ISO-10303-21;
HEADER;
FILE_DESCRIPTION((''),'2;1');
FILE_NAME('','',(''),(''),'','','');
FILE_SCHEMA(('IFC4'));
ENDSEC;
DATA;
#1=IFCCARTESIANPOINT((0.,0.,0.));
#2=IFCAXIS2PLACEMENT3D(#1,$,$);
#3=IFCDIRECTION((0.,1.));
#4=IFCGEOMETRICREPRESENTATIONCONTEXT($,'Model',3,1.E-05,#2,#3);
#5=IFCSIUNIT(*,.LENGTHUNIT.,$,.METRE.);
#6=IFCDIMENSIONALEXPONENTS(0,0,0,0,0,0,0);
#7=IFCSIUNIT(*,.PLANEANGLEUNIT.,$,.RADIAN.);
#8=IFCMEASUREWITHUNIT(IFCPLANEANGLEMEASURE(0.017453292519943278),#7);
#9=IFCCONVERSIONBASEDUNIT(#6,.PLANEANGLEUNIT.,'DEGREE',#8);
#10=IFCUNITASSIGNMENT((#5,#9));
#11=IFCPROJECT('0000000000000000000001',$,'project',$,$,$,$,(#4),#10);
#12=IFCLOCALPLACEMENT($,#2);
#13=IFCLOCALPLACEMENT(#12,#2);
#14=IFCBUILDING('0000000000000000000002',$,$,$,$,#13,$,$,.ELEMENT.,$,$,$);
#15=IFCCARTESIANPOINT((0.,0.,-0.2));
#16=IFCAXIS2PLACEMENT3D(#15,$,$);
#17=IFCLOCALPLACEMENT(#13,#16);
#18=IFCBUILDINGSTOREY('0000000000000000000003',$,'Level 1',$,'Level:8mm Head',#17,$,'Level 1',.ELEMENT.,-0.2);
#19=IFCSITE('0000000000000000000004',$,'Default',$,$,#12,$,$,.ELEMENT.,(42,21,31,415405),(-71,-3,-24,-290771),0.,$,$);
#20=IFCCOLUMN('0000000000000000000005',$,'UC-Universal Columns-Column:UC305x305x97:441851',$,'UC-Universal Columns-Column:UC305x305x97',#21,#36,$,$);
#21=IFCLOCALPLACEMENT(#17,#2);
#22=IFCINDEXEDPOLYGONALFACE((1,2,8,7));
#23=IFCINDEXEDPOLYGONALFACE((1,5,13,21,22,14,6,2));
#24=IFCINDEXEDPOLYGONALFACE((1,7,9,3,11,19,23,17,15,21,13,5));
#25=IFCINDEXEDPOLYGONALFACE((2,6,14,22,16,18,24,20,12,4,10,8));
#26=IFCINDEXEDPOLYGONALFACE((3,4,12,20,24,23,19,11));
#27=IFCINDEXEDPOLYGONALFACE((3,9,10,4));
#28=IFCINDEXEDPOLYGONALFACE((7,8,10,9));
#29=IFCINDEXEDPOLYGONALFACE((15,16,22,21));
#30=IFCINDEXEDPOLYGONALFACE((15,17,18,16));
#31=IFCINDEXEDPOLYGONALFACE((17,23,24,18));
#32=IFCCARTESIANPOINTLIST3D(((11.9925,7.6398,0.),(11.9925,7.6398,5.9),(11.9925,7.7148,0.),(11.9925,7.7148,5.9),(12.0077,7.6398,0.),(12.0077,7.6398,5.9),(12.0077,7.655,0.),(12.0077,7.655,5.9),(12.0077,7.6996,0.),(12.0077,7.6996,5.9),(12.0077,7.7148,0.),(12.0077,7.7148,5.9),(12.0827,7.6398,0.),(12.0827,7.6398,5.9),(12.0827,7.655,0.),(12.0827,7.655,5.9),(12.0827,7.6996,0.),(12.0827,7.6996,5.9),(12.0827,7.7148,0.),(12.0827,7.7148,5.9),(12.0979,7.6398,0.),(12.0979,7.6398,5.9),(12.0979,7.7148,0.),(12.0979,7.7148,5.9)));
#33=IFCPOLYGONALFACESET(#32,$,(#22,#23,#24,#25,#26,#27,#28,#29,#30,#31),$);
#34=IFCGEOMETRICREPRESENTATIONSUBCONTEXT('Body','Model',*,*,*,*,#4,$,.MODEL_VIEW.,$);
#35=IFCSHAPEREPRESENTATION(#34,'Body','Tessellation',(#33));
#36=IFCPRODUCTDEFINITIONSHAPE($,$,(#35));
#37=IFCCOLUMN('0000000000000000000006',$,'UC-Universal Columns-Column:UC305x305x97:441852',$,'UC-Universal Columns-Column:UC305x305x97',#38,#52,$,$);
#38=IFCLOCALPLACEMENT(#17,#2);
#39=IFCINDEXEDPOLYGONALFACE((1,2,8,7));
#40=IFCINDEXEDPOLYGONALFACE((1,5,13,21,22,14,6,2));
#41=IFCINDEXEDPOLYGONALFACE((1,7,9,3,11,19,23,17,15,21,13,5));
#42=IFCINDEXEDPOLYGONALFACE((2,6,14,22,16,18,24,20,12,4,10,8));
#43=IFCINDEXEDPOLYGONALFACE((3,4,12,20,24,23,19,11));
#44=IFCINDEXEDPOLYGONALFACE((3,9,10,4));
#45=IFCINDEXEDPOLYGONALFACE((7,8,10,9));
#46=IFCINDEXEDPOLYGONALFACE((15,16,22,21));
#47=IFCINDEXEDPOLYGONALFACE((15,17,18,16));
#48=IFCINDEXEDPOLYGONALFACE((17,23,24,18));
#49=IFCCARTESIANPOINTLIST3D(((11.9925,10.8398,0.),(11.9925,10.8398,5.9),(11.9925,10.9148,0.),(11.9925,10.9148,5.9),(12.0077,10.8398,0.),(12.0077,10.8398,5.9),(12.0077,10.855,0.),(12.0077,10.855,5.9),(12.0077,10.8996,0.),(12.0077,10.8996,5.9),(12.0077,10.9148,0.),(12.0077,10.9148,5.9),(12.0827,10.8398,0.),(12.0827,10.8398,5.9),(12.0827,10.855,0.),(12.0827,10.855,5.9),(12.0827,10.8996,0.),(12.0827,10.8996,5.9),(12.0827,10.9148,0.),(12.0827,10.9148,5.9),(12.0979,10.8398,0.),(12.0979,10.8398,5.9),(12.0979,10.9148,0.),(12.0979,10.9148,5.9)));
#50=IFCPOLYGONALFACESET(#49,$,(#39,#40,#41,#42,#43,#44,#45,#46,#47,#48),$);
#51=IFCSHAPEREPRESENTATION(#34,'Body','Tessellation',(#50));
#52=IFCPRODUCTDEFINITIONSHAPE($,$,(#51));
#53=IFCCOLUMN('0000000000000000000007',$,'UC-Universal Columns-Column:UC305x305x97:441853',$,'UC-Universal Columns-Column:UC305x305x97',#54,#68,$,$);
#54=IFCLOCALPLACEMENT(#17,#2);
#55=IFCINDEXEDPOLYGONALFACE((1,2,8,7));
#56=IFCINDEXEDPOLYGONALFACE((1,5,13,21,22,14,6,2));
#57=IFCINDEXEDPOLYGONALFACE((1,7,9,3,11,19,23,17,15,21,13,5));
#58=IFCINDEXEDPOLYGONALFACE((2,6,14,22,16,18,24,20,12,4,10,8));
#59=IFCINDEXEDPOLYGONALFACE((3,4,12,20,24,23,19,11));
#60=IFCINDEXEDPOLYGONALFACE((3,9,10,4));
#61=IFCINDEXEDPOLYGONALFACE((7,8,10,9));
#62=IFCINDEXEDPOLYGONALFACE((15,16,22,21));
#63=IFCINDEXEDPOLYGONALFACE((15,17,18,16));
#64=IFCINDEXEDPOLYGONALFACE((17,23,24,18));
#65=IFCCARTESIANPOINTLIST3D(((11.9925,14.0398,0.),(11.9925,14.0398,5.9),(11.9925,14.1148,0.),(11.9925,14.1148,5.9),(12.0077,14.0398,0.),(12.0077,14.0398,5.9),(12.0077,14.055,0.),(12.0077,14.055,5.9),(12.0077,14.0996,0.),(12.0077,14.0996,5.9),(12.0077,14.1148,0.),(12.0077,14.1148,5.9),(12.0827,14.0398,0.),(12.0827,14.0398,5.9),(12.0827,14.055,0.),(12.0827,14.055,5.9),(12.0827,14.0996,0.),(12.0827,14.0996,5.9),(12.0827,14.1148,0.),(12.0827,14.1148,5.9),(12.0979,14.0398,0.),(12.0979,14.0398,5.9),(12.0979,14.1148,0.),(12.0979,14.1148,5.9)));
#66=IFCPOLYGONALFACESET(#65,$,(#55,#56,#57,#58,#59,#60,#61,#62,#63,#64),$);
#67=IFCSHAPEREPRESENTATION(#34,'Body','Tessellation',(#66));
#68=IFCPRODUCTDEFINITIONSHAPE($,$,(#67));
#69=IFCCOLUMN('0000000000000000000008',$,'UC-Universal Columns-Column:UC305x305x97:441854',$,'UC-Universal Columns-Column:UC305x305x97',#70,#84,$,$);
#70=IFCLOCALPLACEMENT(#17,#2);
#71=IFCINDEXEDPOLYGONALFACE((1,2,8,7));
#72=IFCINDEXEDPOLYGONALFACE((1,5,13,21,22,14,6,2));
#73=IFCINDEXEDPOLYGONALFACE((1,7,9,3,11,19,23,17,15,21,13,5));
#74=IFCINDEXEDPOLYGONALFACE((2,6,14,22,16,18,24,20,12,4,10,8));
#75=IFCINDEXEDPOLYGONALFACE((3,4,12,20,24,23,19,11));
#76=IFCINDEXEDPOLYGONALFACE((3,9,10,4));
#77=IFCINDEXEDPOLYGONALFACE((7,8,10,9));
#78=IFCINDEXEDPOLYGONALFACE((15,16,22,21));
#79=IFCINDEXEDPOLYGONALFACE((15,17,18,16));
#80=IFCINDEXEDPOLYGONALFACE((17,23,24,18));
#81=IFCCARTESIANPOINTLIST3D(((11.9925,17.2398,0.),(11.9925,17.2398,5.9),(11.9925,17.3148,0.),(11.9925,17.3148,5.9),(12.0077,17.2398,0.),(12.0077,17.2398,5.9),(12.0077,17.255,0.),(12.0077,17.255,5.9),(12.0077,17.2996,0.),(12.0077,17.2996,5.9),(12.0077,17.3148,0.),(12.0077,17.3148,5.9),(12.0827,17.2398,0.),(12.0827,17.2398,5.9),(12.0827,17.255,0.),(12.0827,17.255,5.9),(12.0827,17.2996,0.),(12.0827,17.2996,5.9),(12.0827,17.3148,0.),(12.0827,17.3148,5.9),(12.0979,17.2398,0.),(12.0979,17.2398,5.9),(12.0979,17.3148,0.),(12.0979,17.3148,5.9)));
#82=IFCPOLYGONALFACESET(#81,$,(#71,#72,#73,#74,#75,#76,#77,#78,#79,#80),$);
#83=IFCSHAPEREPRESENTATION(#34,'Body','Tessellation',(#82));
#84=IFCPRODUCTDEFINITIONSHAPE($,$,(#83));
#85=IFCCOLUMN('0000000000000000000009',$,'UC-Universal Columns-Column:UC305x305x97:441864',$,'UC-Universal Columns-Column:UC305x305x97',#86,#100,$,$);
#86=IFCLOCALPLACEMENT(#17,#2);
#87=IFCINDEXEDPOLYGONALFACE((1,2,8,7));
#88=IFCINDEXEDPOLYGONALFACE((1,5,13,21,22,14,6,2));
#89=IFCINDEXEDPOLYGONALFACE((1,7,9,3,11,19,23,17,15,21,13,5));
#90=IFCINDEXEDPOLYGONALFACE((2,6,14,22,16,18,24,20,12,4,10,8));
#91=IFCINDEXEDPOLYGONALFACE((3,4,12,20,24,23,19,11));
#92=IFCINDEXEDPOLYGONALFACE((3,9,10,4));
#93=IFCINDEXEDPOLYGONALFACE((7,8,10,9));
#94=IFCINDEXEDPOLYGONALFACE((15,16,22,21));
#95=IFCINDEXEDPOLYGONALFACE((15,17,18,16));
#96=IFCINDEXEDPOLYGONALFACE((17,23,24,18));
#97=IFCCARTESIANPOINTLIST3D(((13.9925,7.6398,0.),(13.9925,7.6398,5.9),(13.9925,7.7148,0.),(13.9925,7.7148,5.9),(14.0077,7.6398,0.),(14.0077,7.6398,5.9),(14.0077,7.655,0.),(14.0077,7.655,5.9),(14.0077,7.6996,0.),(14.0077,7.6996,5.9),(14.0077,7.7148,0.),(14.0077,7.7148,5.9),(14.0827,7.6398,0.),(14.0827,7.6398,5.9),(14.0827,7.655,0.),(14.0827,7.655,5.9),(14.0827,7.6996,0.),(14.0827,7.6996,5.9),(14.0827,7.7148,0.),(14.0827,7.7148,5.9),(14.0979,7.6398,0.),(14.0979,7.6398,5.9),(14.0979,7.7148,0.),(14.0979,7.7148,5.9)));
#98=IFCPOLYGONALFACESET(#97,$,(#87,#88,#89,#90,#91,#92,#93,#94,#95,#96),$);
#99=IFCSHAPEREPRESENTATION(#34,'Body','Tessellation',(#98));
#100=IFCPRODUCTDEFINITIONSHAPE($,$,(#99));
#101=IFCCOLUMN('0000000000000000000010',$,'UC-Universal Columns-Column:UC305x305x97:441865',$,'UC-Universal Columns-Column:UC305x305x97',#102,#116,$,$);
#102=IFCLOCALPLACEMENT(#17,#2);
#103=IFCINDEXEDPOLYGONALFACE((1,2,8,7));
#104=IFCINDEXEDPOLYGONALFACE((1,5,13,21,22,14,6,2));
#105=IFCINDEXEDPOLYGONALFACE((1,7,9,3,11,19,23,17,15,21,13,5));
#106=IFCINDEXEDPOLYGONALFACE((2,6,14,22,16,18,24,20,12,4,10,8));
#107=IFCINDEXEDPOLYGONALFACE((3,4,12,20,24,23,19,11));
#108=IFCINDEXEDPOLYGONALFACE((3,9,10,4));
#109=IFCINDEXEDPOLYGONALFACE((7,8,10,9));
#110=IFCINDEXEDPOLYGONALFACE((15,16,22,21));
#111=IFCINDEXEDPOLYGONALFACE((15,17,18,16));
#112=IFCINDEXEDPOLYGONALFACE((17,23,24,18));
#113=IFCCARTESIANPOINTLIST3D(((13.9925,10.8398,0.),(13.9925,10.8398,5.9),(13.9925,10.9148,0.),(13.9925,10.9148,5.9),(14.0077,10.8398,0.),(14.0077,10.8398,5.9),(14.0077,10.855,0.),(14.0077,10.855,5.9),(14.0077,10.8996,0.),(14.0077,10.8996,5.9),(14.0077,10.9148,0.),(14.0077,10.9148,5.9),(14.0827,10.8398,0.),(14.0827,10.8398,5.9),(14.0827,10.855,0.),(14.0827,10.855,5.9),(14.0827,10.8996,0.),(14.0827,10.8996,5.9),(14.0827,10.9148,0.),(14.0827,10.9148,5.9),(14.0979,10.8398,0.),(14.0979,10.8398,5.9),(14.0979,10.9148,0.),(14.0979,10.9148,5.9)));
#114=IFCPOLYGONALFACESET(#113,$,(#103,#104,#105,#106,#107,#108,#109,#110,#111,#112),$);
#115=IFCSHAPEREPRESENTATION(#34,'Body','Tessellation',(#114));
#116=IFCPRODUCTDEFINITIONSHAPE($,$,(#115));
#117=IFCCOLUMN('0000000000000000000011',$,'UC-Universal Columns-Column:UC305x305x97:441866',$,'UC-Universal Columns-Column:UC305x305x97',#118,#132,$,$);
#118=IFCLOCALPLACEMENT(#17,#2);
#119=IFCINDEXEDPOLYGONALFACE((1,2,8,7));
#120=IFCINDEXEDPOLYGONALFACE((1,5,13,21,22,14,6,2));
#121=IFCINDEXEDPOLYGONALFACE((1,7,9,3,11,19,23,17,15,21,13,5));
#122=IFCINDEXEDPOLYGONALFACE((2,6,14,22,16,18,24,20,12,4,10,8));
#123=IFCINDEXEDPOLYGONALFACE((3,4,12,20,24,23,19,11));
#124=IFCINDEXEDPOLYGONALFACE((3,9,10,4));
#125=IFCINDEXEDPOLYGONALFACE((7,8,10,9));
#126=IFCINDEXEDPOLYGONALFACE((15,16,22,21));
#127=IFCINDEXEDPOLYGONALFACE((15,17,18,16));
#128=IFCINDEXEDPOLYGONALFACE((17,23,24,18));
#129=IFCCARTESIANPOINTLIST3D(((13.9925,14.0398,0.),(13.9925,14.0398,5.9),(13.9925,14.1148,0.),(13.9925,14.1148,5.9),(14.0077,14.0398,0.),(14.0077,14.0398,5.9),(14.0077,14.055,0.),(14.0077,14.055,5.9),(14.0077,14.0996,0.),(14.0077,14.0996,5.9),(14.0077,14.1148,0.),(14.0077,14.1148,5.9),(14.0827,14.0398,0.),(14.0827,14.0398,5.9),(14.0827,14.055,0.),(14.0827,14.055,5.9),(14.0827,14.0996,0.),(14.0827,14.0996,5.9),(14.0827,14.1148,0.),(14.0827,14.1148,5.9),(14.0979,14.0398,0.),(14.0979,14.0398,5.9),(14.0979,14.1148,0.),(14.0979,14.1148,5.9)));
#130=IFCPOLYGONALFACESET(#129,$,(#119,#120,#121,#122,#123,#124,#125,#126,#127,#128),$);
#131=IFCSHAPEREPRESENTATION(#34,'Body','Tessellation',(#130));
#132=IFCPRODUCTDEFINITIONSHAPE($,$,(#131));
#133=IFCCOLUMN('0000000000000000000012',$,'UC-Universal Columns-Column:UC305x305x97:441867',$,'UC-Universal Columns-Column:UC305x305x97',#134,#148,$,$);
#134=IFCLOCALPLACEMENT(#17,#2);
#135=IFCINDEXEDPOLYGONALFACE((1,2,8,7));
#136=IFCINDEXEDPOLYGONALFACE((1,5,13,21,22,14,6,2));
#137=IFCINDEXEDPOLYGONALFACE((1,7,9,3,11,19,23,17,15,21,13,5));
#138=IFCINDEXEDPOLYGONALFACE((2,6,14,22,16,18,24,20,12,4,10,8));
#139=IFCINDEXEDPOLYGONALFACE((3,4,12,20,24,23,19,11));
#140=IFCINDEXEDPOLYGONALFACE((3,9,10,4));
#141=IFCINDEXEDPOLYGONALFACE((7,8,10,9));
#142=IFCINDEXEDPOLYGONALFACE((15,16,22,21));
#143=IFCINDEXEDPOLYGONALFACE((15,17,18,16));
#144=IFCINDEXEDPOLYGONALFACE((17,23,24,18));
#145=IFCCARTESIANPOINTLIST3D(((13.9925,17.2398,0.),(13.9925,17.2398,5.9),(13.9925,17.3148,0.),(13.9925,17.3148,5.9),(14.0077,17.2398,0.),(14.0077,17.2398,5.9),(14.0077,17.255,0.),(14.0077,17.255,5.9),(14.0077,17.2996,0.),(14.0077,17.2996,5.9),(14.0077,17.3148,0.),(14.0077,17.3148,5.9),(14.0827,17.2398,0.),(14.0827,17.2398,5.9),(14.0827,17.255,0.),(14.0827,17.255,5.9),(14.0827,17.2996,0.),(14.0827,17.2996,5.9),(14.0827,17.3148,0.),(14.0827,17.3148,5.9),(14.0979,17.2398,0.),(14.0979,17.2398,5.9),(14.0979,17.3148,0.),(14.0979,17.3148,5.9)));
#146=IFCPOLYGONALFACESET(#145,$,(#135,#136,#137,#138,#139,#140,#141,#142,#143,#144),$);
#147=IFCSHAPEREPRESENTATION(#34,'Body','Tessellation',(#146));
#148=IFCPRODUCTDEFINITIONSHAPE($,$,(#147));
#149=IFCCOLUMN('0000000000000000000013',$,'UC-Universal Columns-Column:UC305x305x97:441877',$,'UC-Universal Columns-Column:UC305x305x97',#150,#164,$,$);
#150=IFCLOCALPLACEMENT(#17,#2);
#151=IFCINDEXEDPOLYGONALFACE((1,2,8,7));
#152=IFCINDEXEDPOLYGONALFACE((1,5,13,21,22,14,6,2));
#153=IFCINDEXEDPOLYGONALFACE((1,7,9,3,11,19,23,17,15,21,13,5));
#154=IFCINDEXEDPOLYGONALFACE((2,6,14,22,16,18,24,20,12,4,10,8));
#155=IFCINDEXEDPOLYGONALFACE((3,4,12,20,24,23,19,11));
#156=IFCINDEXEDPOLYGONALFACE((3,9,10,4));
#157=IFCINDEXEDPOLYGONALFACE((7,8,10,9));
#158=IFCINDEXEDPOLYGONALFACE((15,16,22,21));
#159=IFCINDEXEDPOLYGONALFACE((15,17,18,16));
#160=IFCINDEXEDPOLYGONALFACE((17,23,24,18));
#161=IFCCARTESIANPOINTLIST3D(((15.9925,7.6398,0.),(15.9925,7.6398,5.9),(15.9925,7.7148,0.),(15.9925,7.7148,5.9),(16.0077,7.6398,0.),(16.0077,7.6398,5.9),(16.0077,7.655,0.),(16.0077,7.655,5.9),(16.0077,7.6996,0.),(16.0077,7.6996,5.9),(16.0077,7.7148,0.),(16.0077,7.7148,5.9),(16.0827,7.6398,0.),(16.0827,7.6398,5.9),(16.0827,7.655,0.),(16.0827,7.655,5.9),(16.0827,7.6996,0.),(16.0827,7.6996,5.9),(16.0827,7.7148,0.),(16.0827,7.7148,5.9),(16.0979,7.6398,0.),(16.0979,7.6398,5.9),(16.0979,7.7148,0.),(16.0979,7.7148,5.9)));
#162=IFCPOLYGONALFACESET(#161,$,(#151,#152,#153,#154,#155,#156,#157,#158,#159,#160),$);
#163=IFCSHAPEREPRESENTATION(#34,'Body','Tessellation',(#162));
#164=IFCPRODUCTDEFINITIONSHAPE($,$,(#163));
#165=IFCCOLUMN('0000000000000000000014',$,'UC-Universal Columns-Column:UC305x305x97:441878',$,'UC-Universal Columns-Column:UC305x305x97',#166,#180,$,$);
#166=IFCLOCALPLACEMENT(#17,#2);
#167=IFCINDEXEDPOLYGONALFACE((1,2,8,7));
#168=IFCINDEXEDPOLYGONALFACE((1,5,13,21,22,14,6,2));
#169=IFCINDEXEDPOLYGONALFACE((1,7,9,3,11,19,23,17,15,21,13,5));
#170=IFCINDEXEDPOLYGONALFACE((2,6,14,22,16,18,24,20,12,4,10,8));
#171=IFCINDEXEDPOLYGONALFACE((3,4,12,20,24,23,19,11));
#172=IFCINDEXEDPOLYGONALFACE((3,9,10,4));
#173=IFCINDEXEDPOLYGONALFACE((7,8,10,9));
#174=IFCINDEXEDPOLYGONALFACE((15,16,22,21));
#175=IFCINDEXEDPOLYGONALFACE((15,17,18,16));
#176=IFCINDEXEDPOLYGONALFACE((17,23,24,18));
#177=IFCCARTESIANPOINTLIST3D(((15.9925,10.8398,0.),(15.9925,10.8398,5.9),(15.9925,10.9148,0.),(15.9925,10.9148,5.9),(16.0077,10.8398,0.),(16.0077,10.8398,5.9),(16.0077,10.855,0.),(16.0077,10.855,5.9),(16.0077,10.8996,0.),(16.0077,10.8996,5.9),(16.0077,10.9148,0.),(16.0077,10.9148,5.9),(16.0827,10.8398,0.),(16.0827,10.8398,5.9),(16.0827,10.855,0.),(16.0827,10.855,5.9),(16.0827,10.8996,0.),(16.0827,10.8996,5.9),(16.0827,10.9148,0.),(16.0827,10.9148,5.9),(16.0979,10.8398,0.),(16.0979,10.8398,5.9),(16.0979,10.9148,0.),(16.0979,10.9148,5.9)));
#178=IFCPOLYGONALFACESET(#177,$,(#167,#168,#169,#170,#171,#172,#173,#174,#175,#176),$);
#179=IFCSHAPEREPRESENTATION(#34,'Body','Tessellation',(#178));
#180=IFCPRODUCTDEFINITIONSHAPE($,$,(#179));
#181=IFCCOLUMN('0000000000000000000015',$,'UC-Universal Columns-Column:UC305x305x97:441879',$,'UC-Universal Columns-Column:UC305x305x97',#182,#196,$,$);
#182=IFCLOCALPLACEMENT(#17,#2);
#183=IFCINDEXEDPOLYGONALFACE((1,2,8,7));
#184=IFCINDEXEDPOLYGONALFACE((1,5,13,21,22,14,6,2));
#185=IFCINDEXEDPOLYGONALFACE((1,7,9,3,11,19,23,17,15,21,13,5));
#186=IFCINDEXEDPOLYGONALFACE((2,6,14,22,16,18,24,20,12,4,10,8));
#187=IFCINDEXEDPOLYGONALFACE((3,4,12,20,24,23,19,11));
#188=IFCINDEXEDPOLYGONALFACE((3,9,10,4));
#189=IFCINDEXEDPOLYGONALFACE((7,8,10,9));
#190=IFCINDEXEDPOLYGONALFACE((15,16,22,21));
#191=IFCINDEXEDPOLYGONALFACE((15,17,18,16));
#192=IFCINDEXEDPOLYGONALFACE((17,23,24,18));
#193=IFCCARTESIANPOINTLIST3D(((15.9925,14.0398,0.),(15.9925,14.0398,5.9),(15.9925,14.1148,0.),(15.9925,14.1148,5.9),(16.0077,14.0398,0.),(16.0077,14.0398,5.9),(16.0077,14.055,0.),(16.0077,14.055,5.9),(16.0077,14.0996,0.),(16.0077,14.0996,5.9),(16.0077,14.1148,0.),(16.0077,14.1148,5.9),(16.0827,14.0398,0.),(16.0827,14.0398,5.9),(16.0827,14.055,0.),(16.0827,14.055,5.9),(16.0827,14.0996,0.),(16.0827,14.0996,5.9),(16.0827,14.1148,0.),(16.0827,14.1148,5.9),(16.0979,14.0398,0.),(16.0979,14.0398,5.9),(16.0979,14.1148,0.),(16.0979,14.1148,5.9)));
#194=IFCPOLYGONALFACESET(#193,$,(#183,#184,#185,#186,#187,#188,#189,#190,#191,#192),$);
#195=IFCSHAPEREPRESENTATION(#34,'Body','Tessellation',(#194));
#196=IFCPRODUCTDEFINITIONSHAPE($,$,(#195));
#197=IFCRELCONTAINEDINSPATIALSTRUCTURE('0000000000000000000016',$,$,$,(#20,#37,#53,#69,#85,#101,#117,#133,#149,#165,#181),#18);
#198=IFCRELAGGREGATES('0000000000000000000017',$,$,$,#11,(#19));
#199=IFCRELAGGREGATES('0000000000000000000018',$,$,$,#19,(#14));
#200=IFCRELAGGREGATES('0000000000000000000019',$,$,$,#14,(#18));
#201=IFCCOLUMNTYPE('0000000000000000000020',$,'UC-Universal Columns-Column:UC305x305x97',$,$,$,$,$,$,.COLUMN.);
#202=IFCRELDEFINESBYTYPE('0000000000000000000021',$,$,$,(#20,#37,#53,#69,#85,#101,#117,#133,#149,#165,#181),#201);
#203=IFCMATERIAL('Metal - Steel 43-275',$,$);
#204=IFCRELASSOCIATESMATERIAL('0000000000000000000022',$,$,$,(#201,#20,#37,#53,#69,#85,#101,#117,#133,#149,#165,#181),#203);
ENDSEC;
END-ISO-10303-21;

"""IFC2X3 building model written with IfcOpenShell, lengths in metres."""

from ifc_helpers import new_model, entity, si_unit, converted_unit, direction, frame, frame_2d, origin, place, context, subcontext, project, spatial, polyline, circle_curve, parameter, trimmed, segment, composite_curve, outline, extrude, source, transform, mapped, material, type_object, type_shapes, element, save


model = new_model("IFC2X3")

# Units and contexts
model_context = context("Model", 3, precision=1e-05, world=origin(), true_north=direction((0.0, 1.0)))
body_context = subcontext(model_context, "Body", "Model", "MODEL_VIEW")
ifc_project = project(units=[si_unit("LENGTHUNIT", "METRE"), converted_unit("PLANEANGLEUNIT", "DEGREE", entity("IfcPlaneAngleMeasure", 0.017453292519943278), si_unit("PLANEANGLEUNIT", "RADIAN"), dimensions=[0, 0, 0, 0, 0, 0, 0])], contexts=[model_context])

# Site, building, storey
site_placement = place(None, origin())
site = spatial("IfcSite", under=ifc_project, at=site_placement, Name="Default", CompositionType="ELEMENT", RefLatitude=(42, 21, 31, 415405), RefLongitude=(-71, -3, -24, -290771), RefElevation=0.0)
building_placement = place(site_placement, origin())
building = spatial("IfcBuilding", under=site, at=building_placement, CompositionType="ELEMENT")
storey_placement = place(building_placement, frame((0.0, 0.0, -0.2)))
storey = spatial("IfcBuildingStorey", under=building, at=storey_placement, Name="Level 1", ObjectType="Level:8mm Head", LongName="Level 1", CompositionType="ELEMENT", Elevation=-0.2)

# Columns
ifc_material = material(Name="Metal - Steel 43-275")
column_type = type_object("IfcColumnType", Name="UC-Universal Columns-Column:UC305x305x97", PredefinedType="COLUMN", material=ifc_material)
shared_shape = source(origin(), body_context, "Body", "SweptSolid", [
    extrude(outline(composite_curve([segment(polyline([(-0.0375, -0.0375), (0.0375, -0.0375)]), True, "CONTINUOUS"), segment(polyline([(0.0375, -0.0375), (0.0527, -0.0375)]), True, "CONTINUOUS"), segment(trimmed(circle_curve(frame_2d((0.0527, -0.0223), x_axis=(-1.0, 0.0)), 0.0152), [parameter(0.0)], [parameter(90.0)], True, "PARAMETER"), False, "CONTINUOUS"), segment(polyline([(0.0375, -0.0223), (0.0375, 0.0223)]), True, "CONTINUOUS"), segment(trimmed(circle_curve(frame_2d((0.0527, 0.0223), x_axis=(-1.0, 0.0)), 0.0152), [parameter(270.0)], [parameter(0.0)], True, "PARAMETER"), False, "CONTINUOUS"), segment(polyline([(0.0527, 0.0375), (0.0375, 0.0375)]), True, "CONTINUOUS"), segment(polyline([(0.0375, 0.0375), (-0.0375, 0.0375)]), True, "CONTINUOUS"), segment(polyline([(-0.0375, 0.0375), (-0.0527, 0.0375)]), True, "CONTINUOUS"), segment(trimmed(circle_curve(frame_2d((-0.0527, 0.0223), x_axis=(-1.0, 0.0)), 0.0152), [parameter(180.0)], [parameter(270.0)], True, "PARAMETER"), False, "CONTINUOUS"), segment(polyline([(-0.0375, 0.0223), (-0.0375, -0.0223)]), True, "CONTINUOUS"), segment(trimmed(circle_curve(frame_2d((-0.0527, -0.0223), x_axis=(-1.0, 0.0)), 0.0152), [parameter(90.0)], [parameter(180.0)], True, "PARAMETER"), False, "CONTINUOUS"), segment(polyline([(-0.0527, -0.0375), (-0.0375, -0.0375)]), True, "CONTINUOUS")], self_intersect=False)), frame((0.0, 0.0, -0.2), z_axis=(0.0, 0.0, 1.0), x_axis=(-1.0, 0.0, 0.0)), (0.0, 0.0, 1.0), 5.9),
])
type_shapes(column_type, [shared_shape])
for number, where, z_axis, x_axis, name in (
    (1, (12.0452, 7.6773, 0.2), (0.0, 0.0, 1.0), (-1.0, 0.0, 0.0), "UC-Universal Columns-Column:UC305x305x97:441851"),
    (2, (12.0452, 10.8773, 0.2), (0.0, 0.0, 1.0), (-1.0, 0.0, 0.0), "UC-Universal Columns-Column:UC305x305x97:441852"),
    (3, (12.0452, 14.0773, 0.2), (0.0, 0.0, 1.0), (-1.0, 0.0, 0.0), "UC-Universal Columns-Column:UC305x305x97:441853"),
    (4, (12.0452, 17.2773, 0.2), (0.0, 0.0, 1.0), (-1.0, 0.0, 0.0), "UC-Universal Columns-Column:UC305x305x97:441854"),
    (5, (14.0452, 7.6773, 0.2), (0.0, 0.0, 1.0), (-1.0, 0.0, 0.0), "UC-Universal Columns-Column:UC305x305x97:441864"),
    (6, (14.0452, 10.8773, 0.2), (0.0, 0.0, 1.0), (-1.0, 0.0, 0.0), "UC-Universal Columns-Column:UC305x305x97:441865"),
    (7, (14.0452, 14.0773, 0.2), (0.0, 0.0, 1.0), (-1.0, 0.0, 0.0), "UC-Universal Columns-Column:UC305x305x97:441866"),
    (8, (14.0452, 17.2773, 0.2), (0.0, 0.0, 1.0), (-1.0, 0.0, 0.0), "UC-Universal Columns-Column:UC305x305x97:441867"),
    (9, (16.0452, 7.6773, 0.2), (0.0, 0.0, 1.0), (-1.0, 0.0, 0.0), "UC-Universal Columns-Column:UC305x305x97:441877"),
    (10, (16.0452, 10.8773, 0.2), (0.0, 0.0, 1.0), (-1.0, 0.0, 0.0), "UC-Universal Columns-Column:UC305x305x97:441878"),
    (11, (16.0452, 14.0773, 0.2), (0.0, 0.0, 1.0), (-1.0, 0.0, 0.0), "UC-Universal Columns-Column:UC305x305x97:441879"),
):
    element("IfcColumn", number, at=place(storey_placement, frame(where, z_axis=z_axis, x_axis=x_axis)), inside=storey, type_object=column_type, material=ifc_material, Name=name, ObjectType="UC-Universal Columns-Column:UC305x305x97", context=body_context, shape_type="MappedRepresentation", body=[
        mapped(shared_shape, transform((0.0, 0.0, 0.0), scale=1.0)),
    ])

save(model, "model.ifc")
